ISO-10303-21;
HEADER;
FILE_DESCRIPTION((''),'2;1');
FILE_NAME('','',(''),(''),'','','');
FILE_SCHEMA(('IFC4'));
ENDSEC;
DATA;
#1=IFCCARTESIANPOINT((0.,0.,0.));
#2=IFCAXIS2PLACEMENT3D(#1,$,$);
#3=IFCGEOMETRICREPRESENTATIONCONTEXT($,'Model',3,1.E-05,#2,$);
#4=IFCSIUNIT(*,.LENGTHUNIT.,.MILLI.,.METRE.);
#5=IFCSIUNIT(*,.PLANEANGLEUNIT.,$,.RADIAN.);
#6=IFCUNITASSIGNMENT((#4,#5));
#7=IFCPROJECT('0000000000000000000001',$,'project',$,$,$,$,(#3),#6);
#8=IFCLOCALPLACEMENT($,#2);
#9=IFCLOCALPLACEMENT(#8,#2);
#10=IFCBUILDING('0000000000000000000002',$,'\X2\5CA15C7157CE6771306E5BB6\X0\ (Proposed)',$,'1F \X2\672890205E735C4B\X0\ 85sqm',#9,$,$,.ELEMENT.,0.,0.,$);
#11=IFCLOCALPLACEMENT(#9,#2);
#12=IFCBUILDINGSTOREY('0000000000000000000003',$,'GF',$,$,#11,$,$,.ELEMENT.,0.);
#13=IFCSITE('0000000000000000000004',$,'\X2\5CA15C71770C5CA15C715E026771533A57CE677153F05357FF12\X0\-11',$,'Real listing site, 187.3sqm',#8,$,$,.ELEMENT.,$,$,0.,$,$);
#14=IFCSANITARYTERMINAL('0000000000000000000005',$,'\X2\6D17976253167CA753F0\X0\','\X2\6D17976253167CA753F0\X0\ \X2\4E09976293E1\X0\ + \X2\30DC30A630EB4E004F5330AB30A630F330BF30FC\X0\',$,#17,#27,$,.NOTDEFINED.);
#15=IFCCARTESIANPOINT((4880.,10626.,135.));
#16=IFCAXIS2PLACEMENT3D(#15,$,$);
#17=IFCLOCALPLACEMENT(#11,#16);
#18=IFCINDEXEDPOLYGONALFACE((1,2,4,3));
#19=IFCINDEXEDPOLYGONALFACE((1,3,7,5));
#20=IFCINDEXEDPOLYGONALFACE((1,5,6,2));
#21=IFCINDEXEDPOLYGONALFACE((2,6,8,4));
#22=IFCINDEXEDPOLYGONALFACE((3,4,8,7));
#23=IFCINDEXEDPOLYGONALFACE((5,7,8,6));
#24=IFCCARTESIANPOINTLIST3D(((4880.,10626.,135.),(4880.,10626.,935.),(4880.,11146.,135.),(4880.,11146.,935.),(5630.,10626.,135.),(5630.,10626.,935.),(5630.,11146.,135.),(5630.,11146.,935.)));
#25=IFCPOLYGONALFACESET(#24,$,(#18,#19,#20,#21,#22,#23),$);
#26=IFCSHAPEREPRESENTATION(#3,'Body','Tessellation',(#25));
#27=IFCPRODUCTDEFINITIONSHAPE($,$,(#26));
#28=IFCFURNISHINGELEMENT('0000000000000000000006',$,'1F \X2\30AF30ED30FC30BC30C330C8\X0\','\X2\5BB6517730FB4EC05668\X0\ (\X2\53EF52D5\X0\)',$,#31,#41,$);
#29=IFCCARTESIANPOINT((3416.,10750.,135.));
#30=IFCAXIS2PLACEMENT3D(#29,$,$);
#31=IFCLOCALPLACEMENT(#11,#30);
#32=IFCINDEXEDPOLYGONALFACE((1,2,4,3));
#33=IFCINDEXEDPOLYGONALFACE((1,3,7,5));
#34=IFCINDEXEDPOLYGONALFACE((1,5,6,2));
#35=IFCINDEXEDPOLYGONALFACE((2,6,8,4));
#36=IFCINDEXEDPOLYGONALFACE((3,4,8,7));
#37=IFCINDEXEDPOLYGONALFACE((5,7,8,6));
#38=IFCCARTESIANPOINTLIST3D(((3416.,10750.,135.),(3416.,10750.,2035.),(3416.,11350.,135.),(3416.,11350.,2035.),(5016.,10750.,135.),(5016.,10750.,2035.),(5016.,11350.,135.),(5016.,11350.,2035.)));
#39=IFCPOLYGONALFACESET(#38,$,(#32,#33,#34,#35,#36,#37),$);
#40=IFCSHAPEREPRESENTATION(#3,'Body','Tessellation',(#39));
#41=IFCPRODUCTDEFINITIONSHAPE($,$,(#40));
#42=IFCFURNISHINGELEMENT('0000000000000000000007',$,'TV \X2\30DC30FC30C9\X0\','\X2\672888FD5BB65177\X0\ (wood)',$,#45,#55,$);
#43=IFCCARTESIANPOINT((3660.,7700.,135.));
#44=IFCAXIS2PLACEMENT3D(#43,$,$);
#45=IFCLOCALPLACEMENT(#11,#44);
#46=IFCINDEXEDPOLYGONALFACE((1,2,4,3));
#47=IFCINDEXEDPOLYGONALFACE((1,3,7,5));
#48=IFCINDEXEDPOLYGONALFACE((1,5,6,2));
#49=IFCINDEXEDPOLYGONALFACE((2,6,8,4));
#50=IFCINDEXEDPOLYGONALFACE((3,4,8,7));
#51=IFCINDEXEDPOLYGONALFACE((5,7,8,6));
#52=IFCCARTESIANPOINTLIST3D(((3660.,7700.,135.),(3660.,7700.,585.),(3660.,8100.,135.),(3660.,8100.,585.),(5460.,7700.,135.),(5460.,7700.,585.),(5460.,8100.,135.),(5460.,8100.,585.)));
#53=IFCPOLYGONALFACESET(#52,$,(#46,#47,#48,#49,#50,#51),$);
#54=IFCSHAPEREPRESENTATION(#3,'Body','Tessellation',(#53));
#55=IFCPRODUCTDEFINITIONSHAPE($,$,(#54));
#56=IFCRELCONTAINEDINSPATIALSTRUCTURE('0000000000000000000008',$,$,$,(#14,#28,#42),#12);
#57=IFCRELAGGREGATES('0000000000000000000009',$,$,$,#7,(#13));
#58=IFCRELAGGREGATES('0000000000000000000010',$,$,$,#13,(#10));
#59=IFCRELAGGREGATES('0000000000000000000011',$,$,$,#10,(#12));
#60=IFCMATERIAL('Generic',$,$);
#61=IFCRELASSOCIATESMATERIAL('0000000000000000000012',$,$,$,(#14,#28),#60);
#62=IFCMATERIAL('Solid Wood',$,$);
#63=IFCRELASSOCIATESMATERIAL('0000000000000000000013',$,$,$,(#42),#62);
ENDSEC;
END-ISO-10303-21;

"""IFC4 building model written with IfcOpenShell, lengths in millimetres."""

from ifc_helpers import new_model, si_unit, frame, frame_2d, origin, place, context, project, spatial, rectangle, extrude, material, element, save


model = new_model("IFC4")

# Units and contexts
model_context = context("Model", 3, precision=1e-05, world=origin())
ifc_project = project(units=[si_unit("LENGTHUNIT", "METRE", prefix="MILLI"), si_unit("PLANEANGLEUNIT", "RADIAN")], contexts=[model_context])

# Site, building, storey
site_placement = place(None, origin())
site = spatial("IfcSite", under=ifc_project, at=site_placement, Name="岡山県岡山市東区城東台南２-11", ObjectType="Real listing site, 187.3sqm", CompositionType="ELEMENT", RefElevation=0.0)
building_placement = place(site_placement, origin())
building = spatial("IfcBuilding", under=site, at=building_placement, Name="岡山城東の家 (Proposed)", ObjectType="1F 木造平屋 85sqm", CompositionType="ELEMENT", ElevationOfRefHeight=0.0, ElevationOfTerrain=0.0)
storey_placement = place(building_placement, origin())
storey = spatial("IfcBuildingStorey", under=building, at=storey_placement, Name="GF", CompositionType="ELEMENT", Elevation=0.0)

# Shared definitions
ifc_material_1 = material(Name="Solid Wood")

# Shared definitions
ifc_material_2 = material(Name="Generic")

# Sanitary terminal
sanitary_terminal_1_placement = place(storey_placement, frame((4880.0, 10626.0, 135.0)))
element("IfcSanitaryTerminal", 1, at=sanitary_terminal_1_placement, inside=storey, material=ifc_material_2, Name="洗面化粧台", Description="洗面化粧台 三面鏡 + ボウル一体カウンター", PredefinedType="NOTDEFINED", context=model_context, shape_type="SweptSolid", body=[
    extrude(rectangle(XDim=750.0, YDim=520.0, at=frame_2d((375.0, 260.0))), frame((4880.0, 10626.0, 135.0)), (0.0, 0.0, 1.0), 800.0),
])

# Furnishing elements
furnishing_1_placement = place(storey_placement, frame((3416.0, 10750.0, 135.0)))
element("IfcFurnishingElement", 2, at=furnishing_1_placement, inside=storey, material=ifc_material_2, Name="1F クローゼット", Description="家具・什器 (可動)", context=model_context, shape_type="SweptSolid", body=[
    extrude(rectangle(XDim=1600.0, YDim=600.0, at=frame_2d((800.0, 300.0))), frame((3416.0, 10750.0, 135.0)), (0.0, 0.0, 1.0), 1900.0),
])
furnishing_2_placement = place(storey_placement, frame((3660.0, 7700.0, 135.0)))
element("IfcFurnishingElement", 3, at=furnishing_2_placement, inside=storey, material=ifc_material_1, Name="TV ボード", Description="木製家具 (wood)", context=model_context, shape_type="SweptSolid", body=[
    extrude(rectangle(XDim=1800.0, YDim=400.0, at=frame_2d((900.0, 200.0))), frame((3660.0, 7700.0, 135.0)), (0.0, 0.0, 1.0), 450.0),
])

save(model, "model.ifc")
